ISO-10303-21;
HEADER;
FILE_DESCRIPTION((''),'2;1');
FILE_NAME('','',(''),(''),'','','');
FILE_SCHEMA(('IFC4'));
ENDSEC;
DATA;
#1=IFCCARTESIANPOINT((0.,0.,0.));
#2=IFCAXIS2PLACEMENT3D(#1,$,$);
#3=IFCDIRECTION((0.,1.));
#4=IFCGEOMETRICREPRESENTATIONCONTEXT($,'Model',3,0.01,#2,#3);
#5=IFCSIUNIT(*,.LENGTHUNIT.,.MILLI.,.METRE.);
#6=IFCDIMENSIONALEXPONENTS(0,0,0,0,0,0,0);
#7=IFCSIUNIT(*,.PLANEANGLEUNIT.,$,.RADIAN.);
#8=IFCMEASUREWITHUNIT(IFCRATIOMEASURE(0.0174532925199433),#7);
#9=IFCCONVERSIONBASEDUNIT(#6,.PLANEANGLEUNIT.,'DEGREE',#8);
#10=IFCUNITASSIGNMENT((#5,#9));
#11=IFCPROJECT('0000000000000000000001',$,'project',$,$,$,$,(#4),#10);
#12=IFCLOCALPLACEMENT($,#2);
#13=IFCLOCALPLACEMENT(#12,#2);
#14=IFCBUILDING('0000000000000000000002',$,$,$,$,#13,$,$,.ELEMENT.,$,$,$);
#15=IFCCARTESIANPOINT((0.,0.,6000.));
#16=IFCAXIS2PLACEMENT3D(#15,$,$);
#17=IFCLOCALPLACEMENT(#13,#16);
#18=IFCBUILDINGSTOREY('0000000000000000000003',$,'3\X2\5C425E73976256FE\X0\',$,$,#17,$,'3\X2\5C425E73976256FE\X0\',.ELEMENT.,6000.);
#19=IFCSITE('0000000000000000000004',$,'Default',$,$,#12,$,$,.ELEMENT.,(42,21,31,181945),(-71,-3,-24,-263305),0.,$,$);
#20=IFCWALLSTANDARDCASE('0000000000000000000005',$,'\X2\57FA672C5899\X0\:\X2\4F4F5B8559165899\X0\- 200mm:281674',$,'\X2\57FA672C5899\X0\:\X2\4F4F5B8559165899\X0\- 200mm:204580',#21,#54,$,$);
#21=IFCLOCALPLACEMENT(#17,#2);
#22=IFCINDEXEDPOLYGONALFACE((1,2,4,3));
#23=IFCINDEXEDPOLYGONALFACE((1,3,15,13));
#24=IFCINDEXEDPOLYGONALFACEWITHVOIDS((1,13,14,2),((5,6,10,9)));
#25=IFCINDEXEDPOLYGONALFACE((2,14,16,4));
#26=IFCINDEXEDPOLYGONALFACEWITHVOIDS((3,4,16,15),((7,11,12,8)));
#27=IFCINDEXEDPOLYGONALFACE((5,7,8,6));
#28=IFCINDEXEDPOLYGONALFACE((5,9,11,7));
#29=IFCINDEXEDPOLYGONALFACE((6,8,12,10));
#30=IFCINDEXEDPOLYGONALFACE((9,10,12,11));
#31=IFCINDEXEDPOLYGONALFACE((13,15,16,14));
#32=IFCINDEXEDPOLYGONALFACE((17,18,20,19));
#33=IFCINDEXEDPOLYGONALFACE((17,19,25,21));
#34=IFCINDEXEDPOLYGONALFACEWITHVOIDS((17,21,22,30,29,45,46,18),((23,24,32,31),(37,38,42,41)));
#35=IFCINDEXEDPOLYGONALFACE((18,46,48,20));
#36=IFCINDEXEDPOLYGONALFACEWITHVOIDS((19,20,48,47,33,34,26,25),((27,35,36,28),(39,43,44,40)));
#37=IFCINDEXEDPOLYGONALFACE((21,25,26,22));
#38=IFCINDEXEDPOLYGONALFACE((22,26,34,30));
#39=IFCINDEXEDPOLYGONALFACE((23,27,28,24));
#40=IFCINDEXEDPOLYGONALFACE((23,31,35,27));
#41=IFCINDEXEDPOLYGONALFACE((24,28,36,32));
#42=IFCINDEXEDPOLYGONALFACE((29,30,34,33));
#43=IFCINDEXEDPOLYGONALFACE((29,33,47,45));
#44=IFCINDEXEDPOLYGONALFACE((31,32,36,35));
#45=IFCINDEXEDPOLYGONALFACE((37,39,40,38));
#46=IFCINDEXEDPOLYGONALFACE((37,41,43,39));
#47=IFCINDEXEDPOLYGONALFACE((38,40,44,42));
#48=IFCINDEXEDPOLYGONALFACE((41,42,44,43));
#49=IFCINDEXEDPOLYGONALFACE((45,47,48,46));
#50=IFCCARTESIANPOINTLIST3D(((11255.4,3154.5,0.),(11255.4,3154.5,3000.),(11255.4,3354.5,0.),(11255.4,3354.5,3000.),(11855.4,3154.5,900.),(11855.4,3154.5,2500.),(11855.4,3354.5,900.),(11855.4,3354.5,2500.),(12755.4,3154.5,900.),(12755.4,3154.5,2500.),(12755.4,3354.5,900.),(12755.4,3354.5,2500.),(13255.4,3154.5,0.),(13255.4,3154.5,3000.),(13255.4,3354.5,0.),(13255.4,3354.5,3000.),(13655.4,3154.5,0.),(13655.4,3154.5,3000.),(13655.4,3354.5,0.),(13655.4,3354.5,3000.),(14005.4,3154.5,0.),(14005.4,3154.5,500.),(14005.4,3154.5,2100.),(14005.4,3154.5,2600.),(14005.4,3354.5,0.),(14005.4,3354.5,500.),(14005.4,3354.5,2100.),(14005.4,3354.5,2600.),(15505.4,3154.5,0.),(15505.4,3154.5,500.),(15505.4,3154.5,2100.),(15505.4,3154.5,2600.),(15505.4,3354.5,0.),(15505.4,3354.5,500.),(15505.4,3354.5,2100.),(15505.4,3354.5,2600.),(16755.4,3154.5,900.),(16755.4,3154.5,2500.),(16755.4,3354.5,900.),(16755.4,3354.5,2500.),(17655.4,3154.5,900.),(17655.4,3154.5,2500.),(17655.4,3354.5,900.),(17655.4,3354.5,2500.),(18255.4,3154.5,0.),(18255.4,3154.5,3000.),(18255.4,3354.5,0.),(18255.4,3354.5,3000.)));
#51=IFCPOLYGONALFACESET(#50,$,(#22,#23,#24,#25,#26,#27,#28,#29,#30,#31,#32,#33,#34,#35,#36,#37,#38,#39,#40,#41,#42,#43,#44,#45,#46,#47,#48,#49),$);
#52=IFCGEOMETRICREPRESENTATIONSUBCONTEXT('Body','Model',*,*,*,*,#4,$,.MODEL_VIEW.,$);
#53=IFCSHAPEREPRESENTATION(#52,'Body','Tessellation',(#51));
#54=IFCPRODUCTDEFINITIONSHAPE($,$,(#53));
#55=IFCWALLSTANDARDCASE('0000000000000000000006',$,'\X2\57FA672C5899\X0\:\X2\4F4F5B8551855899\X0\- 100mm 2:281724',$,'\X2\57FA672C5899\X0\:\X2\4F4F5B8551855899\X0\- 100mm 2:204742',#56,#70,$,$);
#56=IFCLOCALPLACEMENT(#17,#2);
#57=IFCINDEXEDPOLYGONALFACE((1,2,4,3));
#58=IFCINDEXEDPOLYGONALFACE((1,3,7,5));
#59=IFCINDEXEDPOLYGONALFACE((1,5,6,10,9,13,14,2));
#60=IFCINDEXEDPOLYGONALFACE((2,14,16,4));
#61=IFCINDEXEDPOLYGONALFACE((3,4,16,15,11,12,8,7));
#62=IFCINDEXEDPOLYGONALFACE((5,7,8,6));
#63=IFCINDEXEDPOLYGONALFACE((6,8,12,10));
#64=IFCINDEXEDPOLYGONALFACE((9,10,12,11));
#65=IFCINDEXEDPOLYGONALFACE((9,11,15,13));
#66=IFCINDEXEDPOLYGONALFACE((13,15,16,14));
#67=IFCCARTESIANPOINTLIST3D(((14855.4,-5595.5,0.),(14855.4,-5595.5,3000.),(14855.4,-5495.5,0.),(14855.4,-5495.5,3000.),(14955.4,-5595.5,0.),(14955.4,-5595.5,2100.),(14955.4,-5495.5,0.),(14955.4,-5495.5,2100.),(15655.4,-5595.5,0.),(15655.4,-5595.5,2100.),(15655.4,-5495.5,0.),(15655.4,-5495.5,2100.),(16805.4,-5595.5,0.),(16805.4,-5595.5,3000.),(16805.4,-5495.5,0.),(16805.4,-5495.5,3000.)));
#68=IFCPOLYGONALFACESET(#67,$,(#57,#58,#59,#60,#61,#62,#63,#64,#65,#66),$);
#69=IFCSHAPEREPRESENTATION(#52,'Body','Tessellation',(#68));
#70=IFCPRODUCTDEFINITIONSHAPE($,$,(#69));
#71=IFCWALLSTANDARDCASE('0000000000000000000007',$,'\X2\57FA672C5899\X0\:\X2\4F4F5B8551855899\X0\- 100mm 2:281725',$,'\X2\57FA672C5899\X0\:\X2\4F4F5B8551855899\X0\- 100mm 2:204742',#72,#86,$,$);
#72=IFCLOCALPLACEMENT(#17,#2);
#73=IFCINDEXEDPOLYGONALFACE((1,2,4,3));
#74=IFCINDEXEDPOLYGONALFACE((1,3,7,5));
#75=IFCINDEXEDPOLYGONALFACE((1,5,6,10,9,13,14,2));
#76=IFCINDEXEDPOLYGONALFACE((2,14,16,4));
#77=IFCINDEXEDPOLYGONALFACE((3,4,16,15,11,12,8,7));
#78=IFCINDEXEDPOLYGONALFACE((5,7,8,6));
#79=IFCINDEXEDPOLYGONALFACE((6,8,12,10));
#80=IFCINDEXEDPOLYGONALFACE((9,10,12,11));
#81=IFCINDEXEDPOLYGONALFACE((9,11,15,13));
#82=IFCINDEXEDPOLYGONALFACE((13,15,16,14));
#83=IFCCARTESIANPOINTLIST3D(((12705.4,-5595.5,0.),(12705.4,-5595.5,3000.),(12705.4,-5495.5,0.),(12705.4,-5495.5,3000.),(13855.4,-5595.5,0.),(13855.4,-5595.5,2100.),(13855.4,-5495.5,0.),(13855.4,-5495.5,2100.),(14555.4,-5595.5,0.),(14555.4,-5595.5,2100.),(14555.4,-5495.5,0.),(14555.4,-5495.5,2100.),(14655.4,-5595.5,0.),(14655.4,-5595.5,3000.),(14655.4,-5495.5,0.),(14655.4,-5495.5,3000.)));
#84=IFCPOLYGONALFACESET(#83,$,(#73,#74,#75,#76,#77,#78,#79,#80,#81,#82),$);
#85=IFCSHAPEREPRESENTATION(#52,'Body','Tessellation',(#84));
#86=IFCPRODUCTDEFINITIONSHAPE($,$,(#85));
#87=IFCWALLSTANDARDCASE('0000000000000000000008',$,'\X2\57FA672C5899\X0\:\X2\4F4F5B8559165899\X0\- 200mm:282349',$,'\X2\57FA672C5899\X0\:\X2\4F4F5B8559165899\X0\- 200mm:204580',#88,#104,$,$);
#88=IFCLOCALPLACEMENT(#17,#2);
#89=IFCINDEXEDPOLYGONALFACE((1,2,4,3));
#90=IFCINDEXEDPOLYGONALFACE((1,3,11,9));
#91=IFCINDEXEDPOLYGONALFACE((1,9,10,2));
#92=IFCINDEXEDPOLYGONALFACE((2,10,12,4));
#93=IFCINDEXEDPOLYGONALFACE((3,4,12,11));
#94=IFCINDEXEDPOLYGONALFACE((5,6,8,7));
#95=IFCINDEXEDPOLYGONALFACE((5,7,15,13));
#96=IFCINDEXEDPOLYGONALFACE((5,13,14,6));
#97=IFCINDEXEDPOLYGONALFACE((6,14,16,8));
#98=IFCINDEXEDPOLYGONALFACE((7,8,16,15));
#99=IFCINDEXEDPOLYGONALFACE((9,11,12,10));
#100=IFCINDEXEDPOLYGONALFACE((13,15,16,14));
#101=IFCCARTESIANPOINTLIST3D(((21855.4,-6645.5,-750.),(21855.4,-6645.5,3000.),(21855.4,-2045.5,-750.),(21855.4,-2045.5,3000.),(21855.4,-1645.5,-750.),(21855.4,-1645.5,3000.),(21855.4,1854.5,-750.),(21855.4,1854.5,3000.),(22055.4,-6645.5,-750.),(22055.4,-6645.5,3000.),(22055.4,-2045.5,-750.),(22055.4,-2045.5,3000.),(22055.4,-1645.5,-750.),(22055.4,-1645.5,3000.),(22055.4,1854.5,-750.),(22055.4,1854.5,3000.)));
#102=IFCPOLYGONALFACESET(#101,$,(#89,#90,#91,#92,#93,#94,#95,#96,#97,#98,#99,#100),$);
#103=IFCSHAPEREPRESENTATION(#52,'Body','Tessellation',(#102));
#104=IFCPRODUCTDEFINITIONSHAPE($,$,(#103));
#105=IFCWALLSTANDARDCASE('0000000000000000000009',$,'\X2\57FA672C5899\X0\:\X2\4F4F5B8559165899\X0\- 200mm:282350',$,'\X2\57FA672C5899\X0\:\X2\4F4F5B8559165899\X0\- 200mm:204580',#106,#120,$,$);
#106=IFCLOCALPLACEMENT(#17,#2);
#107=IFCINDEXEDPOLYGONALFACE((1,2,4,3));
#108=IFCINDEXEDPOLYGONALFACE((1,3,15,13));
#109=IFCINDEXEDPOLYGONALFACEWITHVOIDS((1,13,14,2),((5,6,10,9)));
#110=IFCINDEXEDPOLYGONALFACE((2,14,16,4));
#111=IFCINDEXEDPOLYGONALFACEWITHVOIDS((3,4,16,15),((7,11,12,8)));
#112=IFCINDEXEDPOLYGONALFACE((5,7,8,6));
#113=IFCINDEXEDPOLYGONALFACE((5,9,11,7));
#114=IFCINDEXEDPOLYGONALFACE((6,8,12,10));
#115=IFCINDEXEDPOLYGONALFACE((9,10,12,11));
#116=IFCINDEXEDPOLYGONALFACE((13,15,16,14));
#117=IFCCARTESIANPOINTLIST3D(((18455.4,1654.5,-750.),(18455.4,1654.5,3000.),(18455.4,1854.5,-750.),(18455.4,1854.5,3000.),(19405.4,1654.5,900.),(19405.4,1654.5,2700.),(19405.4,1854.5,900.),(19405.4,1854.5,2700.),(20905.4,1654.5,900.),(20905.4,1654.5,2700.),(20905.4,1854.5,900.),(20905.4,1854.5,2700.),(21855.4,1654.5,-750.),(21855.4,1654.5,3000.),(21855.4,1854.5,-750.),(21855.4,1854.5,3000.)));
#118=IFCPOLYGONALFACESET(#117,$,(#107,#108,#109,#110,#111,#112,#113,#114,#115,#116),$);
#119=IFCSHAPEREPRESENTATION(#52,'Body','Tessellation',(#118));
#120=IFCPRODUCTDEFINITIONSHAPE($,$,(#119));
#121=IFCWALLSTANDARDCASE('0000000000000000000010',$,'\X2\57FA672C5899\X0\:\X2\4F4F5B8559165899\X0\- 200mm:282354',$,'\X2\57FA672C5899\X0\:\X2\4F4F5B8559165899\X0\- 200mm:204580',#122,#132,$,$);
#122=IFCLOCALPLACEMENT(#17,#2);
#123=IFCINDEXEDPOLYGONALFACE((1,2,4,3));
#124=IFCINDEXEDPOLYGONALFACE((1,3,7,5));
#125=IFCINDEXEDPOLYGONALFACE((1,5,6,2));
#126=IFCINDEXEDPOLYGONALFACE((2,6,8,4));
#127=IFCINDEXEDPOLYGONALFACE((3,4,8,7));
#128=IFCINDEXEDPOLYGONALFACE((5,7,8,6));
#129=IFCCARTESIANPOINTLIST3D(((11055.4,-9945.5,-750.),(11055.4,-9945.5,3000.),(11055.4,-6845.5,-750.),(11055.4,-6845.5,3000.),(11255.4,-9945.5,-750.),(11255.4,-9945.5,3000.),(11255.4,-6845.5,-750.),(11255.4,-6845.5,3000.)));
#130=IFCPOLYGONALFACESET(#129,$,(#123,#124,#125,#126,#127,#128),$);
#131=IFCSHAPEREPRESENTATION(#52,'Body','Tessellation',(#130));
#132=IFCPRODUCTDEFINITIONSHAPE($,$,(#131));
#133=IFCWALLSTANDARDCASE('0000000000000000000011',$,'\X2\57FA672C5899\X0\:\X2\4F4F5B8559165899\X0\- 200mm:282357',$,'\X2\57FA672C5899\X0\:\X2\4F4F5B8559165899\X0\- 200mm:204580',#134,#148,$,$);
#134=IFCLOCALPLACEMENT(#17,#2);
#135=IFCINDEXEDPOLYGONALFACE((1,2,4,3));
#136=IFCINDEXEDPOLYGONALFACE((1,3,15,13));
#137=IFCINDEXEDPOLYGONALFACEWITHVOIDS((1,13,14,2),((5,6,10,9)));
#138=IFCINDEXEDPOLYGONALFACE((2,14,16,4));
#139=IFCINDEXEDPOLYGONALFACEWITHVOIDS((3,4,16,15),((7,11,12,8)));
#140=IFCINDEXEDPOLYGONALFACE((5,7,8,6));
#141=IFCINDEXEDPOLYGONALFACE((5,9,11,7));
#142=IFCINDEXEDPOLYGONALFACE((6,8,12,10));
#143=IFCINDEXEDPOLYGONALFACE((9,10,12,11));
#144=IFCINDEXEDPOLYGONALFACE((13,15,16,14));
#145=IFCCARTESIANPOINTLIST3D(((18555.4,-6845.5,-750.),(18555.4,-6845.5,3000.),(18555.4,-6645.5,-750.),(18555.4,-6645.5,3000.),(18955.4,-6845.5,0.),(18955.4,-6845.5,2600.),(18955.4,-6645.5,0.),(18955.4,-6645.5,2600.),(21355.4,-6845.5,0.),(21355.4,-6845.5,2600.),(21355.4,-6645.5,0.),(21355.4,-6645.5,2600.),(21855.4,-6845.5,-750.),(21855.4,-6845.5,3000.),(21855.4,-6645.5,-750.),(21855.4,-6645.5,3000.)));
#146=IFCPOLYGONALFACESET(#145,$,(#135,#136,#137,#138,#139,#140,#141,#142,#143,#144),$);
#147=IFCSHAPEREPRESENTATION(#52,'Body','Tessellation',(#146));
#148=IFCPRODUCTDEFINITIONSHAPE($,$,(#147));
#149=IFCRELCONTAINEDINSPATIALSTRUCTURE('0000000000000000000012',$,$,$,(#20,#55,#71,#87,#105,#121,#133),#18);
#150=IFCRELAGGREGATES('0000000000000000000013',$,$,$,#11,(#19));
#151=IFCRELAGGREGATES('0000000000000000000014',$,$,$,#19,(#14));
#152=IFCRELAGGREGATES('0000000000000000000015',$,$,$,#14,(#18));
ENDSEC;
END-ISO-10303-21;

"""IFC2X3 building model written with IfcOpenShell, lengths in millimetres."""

from ifc_helpers import new_model, entity, si_unit, converted_unit, direction, frame, frame_2d, origin, origin_2d_with_axis, place, context, subcontext, project, spatial, polyline, rectangle, extrude, clip, bounded_halfspace, element, save


model = new_model("IFC2X3")

# Units and contexts
model_context = context("Model", 3, precision=0.01, world=origin(), true_north=direction((0.0, 1.0)))
body_context = subcontext(model_context, "Body", "Model", "MODEL_VIEW")
ifc_project = project(units=[si_unit("LENGTHUNIT", "METRE", prefix="MILLI"), converted_unit("PLANEANGLEUNIT", "DEGREE", entity("IfcRatioMeasure", 0.0174532925199433), si_unit("PLANEANGLEUNIT", "RADIAN"), dimensions=[0, 0, 0, 0, 0, 0, 0])], contexts=[model_context])

# Site, building, storey
site_placement = place(None, origin())
site = spatial("IfcSite", under=ifc_project, at=site_placement, Name="Default", CompositionType="ELEMENT", RefLatitude=(42, 21, 31, 181945), RefLongitude=(-71, -3, -24, -263305), RefElevation=0.0)
building_placement = place(site_placement, origin())
building = spatial("IfcBuilding", under=site, at=building_placement, CompositionType="ELEMENT")
storey_placement = place(building_placement, frame((0.0, 0.0, 6000.0)))
storey = spatial("IfcBuildingStorey", under=building, at=storey_placement, Name="3层平面图", LongName="3层平面图", CompositionType="ELEMENT", Elevation=6000.0)

# Wall, openings
wall_1_placement = place(storey_placement, frame((18255.4, 3254.5, 0.0), z_axis=(0.0, 0.0, 1.0), x_axis=(-1.0, 0.0, 0.0)))
wall_1 = element("IfcWallStandardCase", 1, at=wall_1_placement, inside=storey, Name="基本墙:住宅外墙- 200mm:281674", ObjectType="基本墙:住宅外墙- 200mm:204580", context=body_context, shape_type="SweptSolid", body=[
    extrude(rectangle(XDim=7000.0, YDim=200.0, at=frame_2d((3500.0, 0.0), x_axis=(-1.0, 0.0))), origin(), (0.0, 0.0, 1.0), 3000.0),
])
opening_1_placement = place(wall_1_placement, frame((4250.0, 100.0, 2100.0)))
element("IfcOpeningElement", 2, at=opening_1_placement, cuts=wall_1, ObjectType="Opening", context=body_context, shape_type="SweptSolid", body=[
    extrude(rectangle(XDim=500.0, YDim=1500.0, at=frame_2d((250.0, 750.0), x_axis=(1.0, 0.0))), frame((0.0, 0.0, 0.0), z_axis=(0.0, -1.0, 0.0), x_axis=(0.0, 0.0, 1.0)), (0.0, 0.0, 1.0), 200.0),
])
opening_2_placement = place(wall_1_placement, frame((5500.0, -100.0, 900.0)))
element("IfcOpeningElement", 3, at=opening_2_placement, cuts=wall_1, ObjectType="Opening", context=body_context, shape_type="SweptSolid", body=[
    extrude(rectangle(XDim=1600.0, YDim=900.0, at=frame_2d((800.0, 450.0), x_axis=(1.0, 0.0))), frame((0.0, 0.0, 0.0), z_axis=(0.0, 1.0, 0.0), x_axis=(0.0, 0.0, 1.0)), (0.0, 0.0, 1.0), 200.0),
])
opening_3_placement = place(wall_1_placement, frame((600.0, -100.0, 900.0)))
element("IfcOpeningElement", 4, at=opening_3_placement, cuts=wall_1, ObjectType="Opening", context=body_context, shape_type="SweptSolid", body=[
    extrude(rectangle(XDim=1600.0, YDim=900.0, at=frame_2d((800.0, 450.0), x_axis=(1.0, 0.0))), frame((0.0, 0.0, 0.0), z_axis=(0.0, 1.0, 0.0), x_axis=(0.0, 0.0, 1.0)), (0.0, 0.0, 1.0), 200.0),
])
opening_4_placement = place(wall_1_placement, origin())
element("IfcOpeningElement", 5, at=opening_4_placement, cuts=wall_1, ObjectType="Opening", context=body_context, shape_type="SweptSolid", body=[
    extrude(rectangle(XDim=500.0, YDim=1500.0, at=frame_2d((0.0, 0.0), x_axis=(0.0, 1.0))), frame((3500.0, -1424.0, 3250.0), z_axis=(0.0, 1.0, 0.0), x_axis=(-1.0, 0.0, 0.0)), (0.0, 0.0, 1.0), 3048.0),
])
opening_5_placement = place(wall_1_placement, origin())
element("IfcOpeningElement", 6, at=opening_5_placement, cuts=wall_1, ObjectType="Opening", context=body_context, shape_type="SweptSolid", body=[
    extrude(rectangle(XDim=500.0, YDim=1500.0, at=frame_2d((0.0, 0.0), x_axis=(0.0, 1.0))), frame((3500.0, -1424.0, 250.0), z_axis=(0.0, 1.0, 0.0), x_axis=(-1.0, 0.0, 0.0)), (0.0, 0.0, 1.0), 3048.0),
])
opening_6_placement = place(storey_placement, frame((18255.4, 3254.5, 0.0), z_axis=(0.0, 0.0, 1.0), x_axis=(-1.0, 0.0, 0.0)))
element("IfcOpeningElement", 7, at=opening_6_placement, cuts=wall_1, ObjectType="Opening", context=body_context, shape_type="SweptSolid", body=[
    extrude(rectangle(XDim=3000.0, YDim=200.0, at=origin_2d_with_axis()), frame((5000.0, 0.0, 1500.0), z_axis=(-1.0, 0.0, 0.0), x_axis=(0.0, 0.0, 1.0)), (0.0, 0.0, 1.0), 400.0),
])

# Walls, openings
wall_2_placement = place(storey_placement, frame((16805.4, -5545.5, 0.0), z_axis=(0.0, 0.0, 1.0), x_axis=(-1.0, 0.0, 0.0)))
wall_2 = element("IfcWallStandardCase", 8, at=wall_2_placement, inside=storey, Name="基本墙:住宅内墙- 100mm 2:281724", ObjectType="基本墙:住宅内墙- 100mm 2:204742", context=body_context, shape_type="SweptSolid", body=[
    extrude(rectangle(XDim=1950.0, YDim=100.0, at=frame_2d((975.0, 0.0), x_axis=(-1.0, 0.0))), origin(), (0.0, 0.0, 1.0), 3000.0),
])
opening_7_placement = place(wall_2_placement, frame((1850.0, 50.0, 0.0)))
element("IfcOpeningElement", 9, at=opening_7_placement, cuts=wall_2, ObjectType="Opening", context=body_context, shape_type="SweptSolid", body=[
    extrude(rectangle(XDim=2100.0, YDim=700.0, at=frame_2d((1050.0, 350.0), x_axis=(1.0, 0.0))), frame((0.0, 0.0, 0.0), z_axis=(0.0, -1.0, 0.0), x_axis=(0.0, 0.0, 1.0)), (0.0, 0.0, 1.0), 100.0),
])
wall_3_placement = place(storey_placement, frame((12705.4, -5545.5, 0.0)))
wall_3 = element("IfcWallStandardCase", 10, at=wall_3_placement, inside=storey, Name="基本墙:住宅内墙- 100mm 2:281725", ObjectType="基本墙:住宅内墙- 100mm 2:204742", context=body_context, shape_type="SweptSolid", body=[
    extrude(rectangle(XDim=1950.0, YDim=100.0, at=frame_2d((975.0, 0.0), x_axis=(-1.0, 0.0))), origin(), (0.0, 0.0, 1.0), 3000.0),
])
opening_8_placement = place(wall_3_placement, frame((1150.0, -50.0, 0.0)))
element("IfcOpeningElement", 11, at=opening_8_placement, cuts=wall_3, ObjectType="Opening", context=body_context, shape_type="SweptSolid", body=[
    extrude(rectangle(XDim=2100.0, YDim=700.0, at=frame_2d((1050.0, 350.0), x_axis=(1.0, 0.0))), frame((0.0, 0.0, 0.0), z_axis=(0.0, 1.0, 0.0), x_axis=(0.0, 0.0, 1.0)), (0.0, 0.0, 1.0), 100.0),
])
wall_4_placement = place(storey_placement, frame((21955.4, -6645.5, -750.0), z_axis=(0.0, 0.0, 1.0), x_axis=(0.0, 1.0, 0.0)))
wall_4 = element("IfcWallStandardCase", 12, at=wall_4_placement, inside=storey, Name="基本墙:住宅外墙- 200mm:282349", ObjectType="基本墙:住宅外墙- 200mm:204580", context=body_context, shape_type="SweptSolid", body=[
    extrude(rectangle(XDim=8500.0, YDim=200.0, at=frame_2d((4250.0, 0.0), x_axis=(-1.0, 0.0))), origin(), (0.0, 0.0, 1.0), 3750.0),
])
opening_9_placement = place(storey_placement, frame((21955.4, -6645.5, -750.0), z_axis=(0.0, 0.0, 1.0), x_axis=(0.0, 1.0, 0.0)))
element("IfcOpeningElement", 13, at=opening_9_placement, cuts=wall_4, ObjectType="Opening", context=body_context, shape_type="SweptSolid", body=[
    extrude(rectangle(XDim=3750.0, YDim=200.0, at=frame_2d((0.0, 0.0), x_axis=(1.0, 0.0))), frame((4600.0, 0.0, 1875.0), z_axis=(1.0, 0.0, 0.0), x_axis=(0.0, 0.0, -1.0)), (0.0, 0.0, 1.0), 400.0),
])
wall_5_placement = place(storey_placement, frame((21855.4, 1754.5, -750.0), z_axis=(0.0, 0.0, 1.0), x_axis=(-1.0, 0.0, 0.0)))
wall_5 = element("IfcWallStandardCase", 14, at=wall_5_placement, inside=storey, Name="基本墙:住宅外墙- 200mm:282350", ObjectType="基本墙:住宅外墙- 200mm:204580", context=body_context, shape_type="SweptSolid", body=[
    extrude(rectangle(XDim=3400.0, YDim=200.0, at=frame_2d((1700.0, 0.0), x_axis=(-1.0, 0.0))), origin(), (0.0, 0.0, 1.0), 3750.0),
])
opening_10_placement = place(wall_5_placement, frame((2450.0, 100.0, 1650.0)))
element("IfcOpeningElement", 15, at=opening_10_placement, cuts=wall_5, ObjectType="Opening", context=body_context, shape_type="SweptSolid", body=[
    extrude(rectangle(XDim=1800.0, YDim=1500.0, at=frame_2d((900.0, 750.0), x_axis=(1.0, 0.0))), frame((0.0, 0.0, 0.0), z_axis=(0.0, -1.0, 0.0), x_axis=(0.0, 0.0, 1.0)), (0.0, 0.0, 1.0), 200.0),
])

# Wall
wall_6_placement = place(storey_placement, frame((11155.4, -6845.5, -750.0), z_axis=(0.0, 0.0, 1.0), x_axis=(0.0, -1.0, 0.0)))
element("IfcWallStandardCase", 16, at=wall_6_placement, inside=storey, Name="基本墙:住宅外墙- 200mm:282354", ObjectType="基本墙:住宅外墙- 200mm:204580", context=body_context, shape_type="Clipping", body=[
    clip(extrude(rectangle(XDim=3100.0, YDim=200.0, at=frame_2d((1550.0, 0.0), x_axis=(-1.0, 0.0))), origin(), (0.0, 0.0, 1.0), 3750.0), bounded_halfspace(frame((3100.0, -100.0, 3750.0), z_axis=(-1.0, 0.0, 0.0), x_axis=(0.0, 0.0, -1.0)), True, frame((3100.0, -100.0, 3750.0), z_axis=(-1.0, 0.0, 0.0), x_axis=(0.0, 0.0, -1.0)), polyline([(0.0, 0.0), (0.0, -200.0), (3750.0, -200.0), (3750.0, 0.0), (0.0, 0.0)]))),
])

# Wall, opening
wall_7_placement = place(storey_placement, frame((18555.4, -6745.5, -750.0)))
wall_7 = element("IfcWallStandardCase", 17, at=wall_7_placement, inside=storey, Name="基本墙:住宅外墙- 200mm:282357", ObjectType="基本墙:住宅外墙- 200mm:204580", context=body_context, shape_type="Clipping", body=[
    clip(extrude(rectangle(XDim=3300.0, YDim=200.0, at=frame_2d((1650.0, 0.0), x_axis=(-1.0, 0.0))), origin(), (0.0, 0.0, 1.0), 3750.0), bounded_halfspace(frame((0.0, -100.0, 0.0), z_axis=(-1.0, 0.0, 0.0), x_axis=(0.0, 0.0, -1.0)), False, frame((0.0, -100.0, 0.0), z_axis=(-1.0, 0.0, 0.0), x_axis=(0.0, 0.0, -1.0)), polyline([(0.0, 0.0), (-3750.0, 0.0), (-3750.0, -200.0), (0.0, -200.0), (0.0, 0.0)]))),
])
opening_11_placement = place(wall_7_placement, origin())
element("IfcOpeningElement", 18, at=opening_11_placement, cuts=wall_7, ObjectType="Opening", context=body_context, shape_type="SweptSolid", body=[
    extrude(rectangle(XDim=2600.0, YDim=2400.0, at=frame_2d((0.0, 0.0), x_axis=(0.0, 1.0))), frame((1600.0, -1424.0, 2050.0), z_axis=(0.0, 1.0, 0.0), x_axis=(-1.0, 0.0, 0.0)), (0.0, 0.0, 1.0), 3048.0),
])

save(model, "model.ifc")
